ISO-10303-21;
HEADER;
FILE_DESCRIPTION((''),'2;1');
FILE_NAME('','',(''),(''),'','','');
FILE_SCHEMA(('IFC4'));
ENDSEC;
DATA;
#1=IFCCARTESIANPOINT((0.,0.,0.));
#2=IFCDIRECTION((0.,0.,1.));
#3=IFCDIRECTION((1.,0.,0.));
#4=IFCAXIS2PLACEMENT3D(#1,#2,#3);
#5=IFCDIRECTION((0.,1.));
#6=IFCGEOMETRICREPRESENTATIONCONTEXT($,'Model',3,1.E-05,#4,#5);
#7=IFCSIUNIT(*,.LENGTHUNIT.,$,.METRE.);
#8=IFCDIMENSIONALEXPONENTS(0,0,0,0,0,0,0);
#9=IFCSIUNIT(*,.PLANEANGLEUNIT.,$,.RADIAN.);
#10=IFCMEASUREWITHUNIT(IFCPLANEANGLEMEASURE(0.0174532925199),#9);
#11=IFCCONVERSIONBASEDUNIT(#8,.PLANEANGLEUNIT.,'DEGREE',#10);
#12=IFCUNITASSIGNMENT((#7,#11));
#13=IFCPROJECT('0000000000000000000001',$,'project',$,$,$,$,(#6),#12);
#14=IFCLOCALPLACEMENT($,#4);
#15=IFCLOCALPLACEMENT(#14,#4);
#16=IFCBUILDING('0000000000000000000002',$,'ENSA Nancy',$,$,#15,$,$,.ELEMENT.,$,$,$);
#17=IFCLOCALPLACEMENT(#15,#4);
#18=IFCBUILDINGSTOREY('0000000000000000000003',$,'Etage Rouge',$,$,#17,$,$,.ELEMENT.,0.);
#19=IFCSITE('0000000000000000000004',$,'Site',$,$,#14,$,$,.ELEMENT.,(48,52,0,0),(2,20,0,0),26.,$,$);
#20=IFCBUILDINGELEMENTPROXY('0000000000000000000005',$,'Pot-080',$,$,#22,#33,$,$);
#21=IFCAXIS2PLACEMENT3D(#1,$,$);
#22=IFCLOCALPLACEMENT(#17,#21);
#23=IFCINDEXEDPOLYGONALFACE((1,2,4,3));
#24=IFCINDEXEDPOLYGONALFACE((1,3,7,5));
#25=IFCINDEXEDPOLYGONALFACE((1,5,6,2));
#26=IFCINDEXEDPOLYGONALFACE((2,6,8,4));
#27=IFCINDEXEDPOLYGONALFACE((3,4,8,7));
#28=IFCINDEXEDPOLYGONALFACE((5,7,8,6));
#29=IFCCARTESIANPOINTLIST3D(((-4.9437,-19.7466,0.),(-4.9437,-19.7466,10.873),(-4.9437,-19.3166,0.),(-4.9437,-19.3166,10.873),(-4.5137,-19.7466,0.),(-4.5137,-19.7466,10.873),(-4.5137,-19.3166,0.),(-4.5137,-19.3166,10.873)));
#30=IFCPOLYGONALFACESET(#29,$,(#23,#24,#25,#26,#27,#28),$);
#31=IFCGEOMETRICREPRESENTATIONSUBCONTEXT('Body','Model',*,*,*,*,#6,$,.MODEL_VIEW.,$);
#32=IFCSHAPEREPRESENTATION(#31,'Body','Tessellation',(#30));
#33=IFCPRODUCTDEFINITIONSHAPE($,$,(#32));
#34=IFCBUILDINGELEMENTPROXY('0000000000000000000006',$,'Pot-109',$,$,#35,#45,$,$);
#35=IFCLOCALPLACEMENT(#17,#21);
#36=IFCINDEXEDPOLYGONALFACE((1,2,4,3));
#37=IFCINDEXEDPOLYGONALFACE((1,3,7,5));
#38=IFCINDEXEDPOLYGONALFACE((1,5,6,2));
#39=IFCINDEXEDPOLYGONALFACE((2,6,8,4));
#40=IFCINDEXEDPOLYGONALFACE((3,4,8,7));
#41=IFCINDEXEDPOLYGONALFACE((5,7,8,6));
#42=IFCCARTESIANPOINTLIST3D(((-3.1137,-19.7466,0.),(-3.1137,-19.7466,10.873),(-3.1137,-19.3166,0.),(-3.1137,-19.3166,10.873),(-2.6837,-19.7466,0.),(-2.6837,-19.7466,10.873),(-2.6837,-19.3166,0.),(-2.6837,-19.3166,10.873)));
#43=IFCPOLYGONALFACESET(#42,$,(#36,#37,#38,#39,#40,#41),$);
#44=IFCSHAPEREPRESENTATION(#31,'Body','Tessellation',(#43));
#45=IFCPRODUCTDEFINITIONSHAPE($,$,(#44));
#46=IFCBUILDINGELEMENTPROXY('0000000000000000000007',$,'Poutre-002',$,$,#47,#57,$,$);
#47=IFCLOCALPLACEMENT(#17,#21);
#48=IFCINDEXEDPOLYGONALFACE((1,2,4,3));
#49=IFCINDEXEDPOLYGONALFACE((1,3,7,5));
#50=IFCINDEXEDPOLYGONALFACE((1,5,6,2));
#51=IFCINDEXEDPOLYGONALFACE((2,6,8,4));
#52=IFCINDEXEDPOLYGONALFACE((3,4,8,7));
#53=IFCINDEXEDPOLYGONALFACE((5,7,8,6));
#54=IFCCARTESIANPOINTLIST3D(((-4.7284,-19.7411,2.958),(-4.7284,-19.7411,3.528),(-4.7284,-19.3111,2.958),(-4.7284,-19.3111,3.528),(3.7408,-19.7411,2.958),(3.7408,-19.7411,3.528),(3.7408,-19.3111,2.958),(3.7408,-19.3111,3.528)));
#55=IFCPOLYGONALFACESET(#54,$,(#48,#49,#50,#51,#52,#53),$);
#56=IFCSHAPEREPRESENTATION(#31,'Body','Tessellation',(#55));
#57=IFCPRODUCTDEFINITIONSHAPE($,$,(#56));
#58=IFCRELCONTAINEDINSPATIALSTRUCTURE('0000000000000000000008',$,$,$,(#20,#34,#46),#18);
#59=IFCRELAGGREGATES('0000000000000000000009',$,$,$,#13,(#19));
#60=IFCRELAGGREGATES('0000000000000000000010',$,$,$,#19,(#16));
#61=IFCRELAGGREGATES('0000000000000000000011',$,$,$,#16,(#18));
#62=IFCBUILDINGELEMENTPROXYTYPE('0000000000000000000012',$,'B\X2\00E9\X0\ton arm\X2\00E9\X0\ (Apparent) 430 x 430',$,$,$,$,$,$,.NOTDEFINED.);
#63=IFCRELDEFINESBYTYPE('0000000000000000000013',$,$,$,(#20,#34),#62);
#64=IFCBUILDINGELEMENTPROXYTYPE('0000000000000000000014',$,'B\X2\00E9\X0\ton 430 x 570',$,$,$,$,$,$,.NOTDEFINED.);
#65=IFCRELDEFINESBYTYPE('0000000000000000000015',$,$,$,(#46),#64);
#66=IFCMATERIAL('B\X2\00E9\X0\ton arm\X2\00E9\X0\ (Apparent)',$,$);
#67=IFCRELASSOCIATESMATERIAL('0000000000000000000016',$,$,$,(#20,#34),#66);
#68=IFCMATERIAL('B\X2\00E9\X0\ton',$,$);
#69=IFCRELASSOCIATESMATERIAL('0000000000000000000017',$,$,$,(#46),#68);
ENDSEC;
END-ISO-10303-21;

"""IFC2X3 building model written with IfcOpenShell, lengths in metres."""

from ifc_helpers import new_model, entity, si_unit, converted_unit, direction, frame, frame_2d, origin_with_axes, origin_2d_with_axis, place, context, subcontext, project, spatial, rectangle, extrude, material, type_object, element, save


model = new_model("IFC2X3")

# Units and contexts
model_context = context("Model", 3, precision=1e-05, world=origin_with_axes(), true_north=direction((0.0, 1.0)))
body_context = subcontext(model_context, "Body", "Model", "MODEL_VIEW")
ifc_project = project(units=[si_unit("LENGTHUNIT", "METRE"), converted_unit("PLANEANGLEUNIT", "DEGREE", entity("IfcPlaneAngleMeasure", 0.0174532925199), si_unit("PLANEANGLEUNIT", "RADIAN"), dimensions=[0, 0, 0, 0, 0, 0, 0])], contexts=[model_context])

# Site, building, storey
site_placement = place(None, origin_with_axes())
site = spatial("IfcSite", under=ifc_project, at=site_placement, Name="Site", CompositionType="ELEMENT", RefLatitude=(48, 52, 0, 0), RefLongitude=(2, 20, 0, 0), RefElevation=26.0)
building_placement = place(site_placement, origin_with_axes())
building = spatial("IfcBuilding", under=site, at=building_placement, Name="ENSA Nancy", CompositionType="ELEMENT")
storey_placement = place(building_placement, origin_with_axes())
storey = spatial("IfcBuildingStorey", under=building, at=storey_placement, Name="Etage Rouge", CompositionType="ELEMENT", Elevation=0.0)

# Building element proxies
ifc_material_1 = material(Name="Béton")
ifc_material_2 = material(Name="Béton armé (Apparent)")
building_element_proxy_type_1 = type_object("IfcBuildingElementProxyType", Name="Béton armé (Apparent) 430 x 430", PredefinedType="NOTDEFINED")
for number, where, z_axis, x_axis, name in (
    (1, (-4.7287, -19.5316, 0.0), (0.0, 0.0, 1.0), (1.0, 0.0, 0.0), "Pot-080"),
    (2, (-2.8987, -19.5316, 0.0), (0.0, 0.0, 1.0), (1.0, 0.0, 0.0), "Pot-109"),
):
    element("IfcBuildingElementProxy", number, at=place(storey_placement, frame(where, z_axis=z_axis, x_axis=x_axis)), inside=storey, type_object=building_element_proxy_type_1, material=ifc_material_2, Name=name, context=body_context, shape_type="SweptSolid", body=[
        extrude(rectangle(XDim=0.43, YDim=0.43, at=origin_2d_with_axis()), origin_with_axes(), (0.0, 0.0, 1.0), 10.873),
    ])
building_element_proxy_type_2 = type_object("IfcBuildingElementProxyType", Name="Béton 430 x 570", PredefinedType="NOTDEFINED")
proxy_1_placement = place(storey_placement, frame((-4.7284, -19.5261, 3.528), z_axis=(0.0, 0.0, 1.0), x_axis=(0.0, -1.0, 0.0)))
element("IfcBuildingElementProxy", 3, at=proxy_1_placement, inside=storey, type_object=building_element_proxy_type_2, material=ifc_material_1, Name="Poutre-002", context=body_context, shape_type="SweptSolid", body=[
    extrude(rectangle(XDim=0.57, YDim=0.43, at=frame_2d((-0.285, 0.0), x_axis=(1.0, 0.0))), frame((0.0, 0.0, 0.0), z_axis=(0.0, 1.0, 0.0), x_axis=(0.0, 0.0, 1.0)), (0.0, 0.0, 1.0), 8.4691),
])

save(model, "model.ifc")
